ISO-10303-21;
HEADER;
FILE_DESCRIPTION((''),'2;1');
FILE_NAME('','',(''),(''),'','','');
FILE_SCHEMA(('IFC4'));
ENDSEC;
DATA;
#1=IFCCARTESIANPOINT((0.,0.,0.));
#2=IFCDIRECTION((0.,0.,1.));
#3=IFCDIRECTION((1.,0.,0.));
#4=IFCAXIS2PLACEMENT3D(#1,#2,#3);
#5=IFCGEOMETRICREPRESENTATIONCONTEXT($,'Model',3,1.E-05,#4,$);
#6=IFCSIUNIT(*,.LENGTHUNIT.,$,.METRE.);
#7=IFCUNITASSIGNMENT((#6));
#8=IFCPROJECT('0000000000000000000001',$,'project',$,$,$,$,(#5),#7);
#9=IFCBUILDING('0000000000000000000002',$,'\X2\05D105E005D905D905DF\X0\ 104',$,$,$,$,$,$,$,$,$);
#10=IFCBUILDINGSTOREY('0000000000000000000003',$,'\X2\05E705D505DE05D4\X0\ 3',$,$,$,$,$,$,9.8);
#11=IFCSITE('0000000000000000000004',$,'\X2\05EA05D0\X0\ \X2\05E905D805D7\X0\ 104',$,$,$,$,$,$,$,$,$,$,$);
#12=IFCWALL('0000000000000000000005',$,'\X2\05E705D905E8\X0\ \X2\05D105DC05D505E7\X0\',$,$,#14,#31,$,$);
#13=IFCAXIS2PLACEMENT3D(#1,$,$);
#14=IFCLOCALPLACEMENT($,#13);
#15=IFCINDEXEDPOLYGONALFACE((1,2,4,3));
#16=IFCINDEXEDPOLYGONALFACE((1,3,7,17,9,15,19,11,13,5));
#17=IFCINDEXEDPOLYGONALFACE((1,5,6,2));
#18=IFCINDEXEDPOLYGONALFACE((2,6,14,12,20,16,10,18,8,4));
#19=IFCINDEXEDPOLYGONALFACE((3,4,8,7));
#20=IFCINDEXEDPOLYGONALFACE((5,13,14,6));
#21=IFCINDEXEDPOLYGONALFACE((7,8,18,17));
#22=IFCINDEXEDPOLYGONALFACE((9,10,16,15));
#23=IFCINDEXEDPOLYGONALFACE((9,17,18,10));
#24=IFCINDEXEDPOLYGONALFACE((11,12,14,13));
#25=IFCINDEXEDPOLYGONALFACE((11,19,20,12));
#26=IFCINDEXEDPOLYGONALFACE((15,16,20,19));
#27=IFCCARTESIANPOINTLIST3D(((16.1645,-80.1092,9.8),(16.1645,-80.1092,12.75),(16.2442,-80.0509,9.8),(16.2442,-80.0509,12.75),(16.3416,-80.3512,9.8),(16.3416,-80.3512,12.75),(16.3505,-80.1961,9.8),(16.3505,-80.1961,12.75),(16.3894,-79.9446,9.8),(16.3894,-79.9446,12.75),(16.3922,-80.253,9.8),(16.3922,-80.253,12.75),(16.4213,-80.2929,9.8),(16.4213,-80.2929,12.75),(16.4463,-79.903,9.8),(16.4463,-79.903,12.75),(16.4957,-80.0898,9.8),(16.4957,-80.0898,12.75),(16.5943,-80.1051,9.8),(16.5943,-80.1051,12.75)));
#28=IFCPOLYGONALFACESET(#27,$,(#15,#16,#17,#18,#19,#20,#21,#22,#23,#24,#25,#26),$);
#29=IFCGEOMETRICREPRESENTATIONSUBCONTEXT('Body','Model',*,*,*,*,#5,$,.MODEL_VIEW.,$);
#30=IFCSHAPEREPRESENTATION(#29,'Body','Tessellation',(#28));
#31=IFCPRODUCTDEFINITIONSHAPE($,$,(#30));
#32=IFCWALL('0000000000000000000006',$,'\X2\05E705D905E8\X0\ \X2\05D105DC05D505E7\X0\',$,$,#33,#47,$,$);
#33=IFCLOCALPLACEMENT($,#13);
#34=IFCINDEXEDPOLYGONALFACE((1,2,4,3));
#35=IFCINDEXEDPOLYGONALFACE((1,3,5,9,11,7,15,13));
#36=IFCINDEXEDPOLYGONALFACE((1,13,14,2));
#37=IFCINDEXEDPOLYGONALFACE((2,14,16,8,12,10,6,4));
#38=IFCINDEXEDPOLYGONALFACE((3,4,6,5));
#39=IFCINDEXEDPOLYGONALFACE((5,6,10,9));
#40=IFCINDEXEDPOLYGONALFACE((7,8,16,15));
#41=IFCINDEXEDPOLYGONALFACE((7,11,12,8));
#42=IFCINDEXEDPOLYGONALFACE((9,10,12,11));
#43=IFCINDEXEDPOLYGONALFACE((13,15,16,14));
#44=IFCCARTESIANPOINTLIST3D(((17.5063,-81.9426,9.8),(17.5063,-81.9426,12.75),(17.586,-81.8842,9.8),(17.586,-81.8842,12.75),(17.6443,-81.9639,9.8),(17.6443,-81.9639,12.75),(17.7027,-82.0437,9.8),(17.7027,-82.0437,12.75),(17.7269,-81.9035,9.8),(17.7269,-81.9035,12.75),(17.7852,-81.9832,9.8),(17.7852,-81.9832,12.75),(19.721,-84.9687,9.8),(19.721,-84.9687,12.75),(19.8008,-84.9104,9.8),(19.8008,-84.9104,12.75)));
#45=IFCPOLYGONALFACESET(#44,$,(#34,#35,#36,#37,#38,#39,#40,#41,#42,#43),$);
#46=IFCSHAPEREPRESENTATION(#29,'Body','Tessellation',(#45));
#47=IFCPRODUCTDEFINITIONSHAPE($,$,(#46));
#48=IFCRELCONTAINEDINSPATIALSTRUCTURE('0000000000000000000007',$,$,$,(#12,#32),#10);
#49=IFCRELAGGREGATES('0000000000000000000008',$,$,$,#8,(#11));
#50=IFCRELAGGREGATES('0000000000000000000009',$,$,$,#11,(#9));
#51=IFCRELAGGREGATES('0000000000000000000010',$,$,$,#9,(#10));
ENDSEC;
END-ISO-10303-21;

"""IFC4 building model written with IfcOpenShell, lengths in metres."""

from ifc_helpers import new_model, si_unit, frame, origin_with_axes, context, subcontext, project, spatial, polyline, outline, extrude, element, save


model = new_model("IFC4")

# Units and contexts
model_context = context("Model", 3, precision=1e-05, world=origin_with_axes())
body_context = subcontext(model_context, "Body", "Model", "MODEL_VIEW")
ifc_project = project(units=[si_unit("LENGTHUNIT", "METRE")], contexts=[model_context])

# Site, building, storey
site = spatial("IfcSite", under=ifc_project, Name="תא שטח 104")
building = spatial("IfcBuilding", under=site, Name="בניין 104")
storey = spatial("IfcBuildingStorey", under=building, Name="קומה 3", Elevation=9.8)

# Walls
element("IfcWall", 1, inside=storey, Name="קיר בלוק", context=body_context, shape_type="SweptSolid", body=[
    extrude(outline(polyline([(16.3894, -79.9446), (16.4957, -80.0898), (16.3505, -80.1961), (16.2442, -80.0509), (16.1645, -80.1092), (16.3416, -80.3512), (16.4213, -80.2929), (16.3922, -80.253), (16.5943, -80.1051), (16.4463, -79.903), (16.3894, -79.9446)])), frame((0.0, 0.0, 9.8)), (0.0, 0.0, 1.0), 2.95),
])
element("IfcWall", 2, inside=storey, Name="קיר בלוק", context=body_context, shape_type="SweptSolid", body=[
    extrude(outline(polyline([(17.5063, -81.9426), (19.721, -84.9687), (19.8008, -84.9104), (17.7027, -82.0437), (17.7852, -81.9832), (17.7269, -81.9035), (17.6443, -81.9639), (17.586, -81.8842), (17.5063, -81.9426)])), frame((0.0, 0.0, 9.8)), (0.0, 0.0, 1.0), 2.95),
])

save(model, "model.ifc")
